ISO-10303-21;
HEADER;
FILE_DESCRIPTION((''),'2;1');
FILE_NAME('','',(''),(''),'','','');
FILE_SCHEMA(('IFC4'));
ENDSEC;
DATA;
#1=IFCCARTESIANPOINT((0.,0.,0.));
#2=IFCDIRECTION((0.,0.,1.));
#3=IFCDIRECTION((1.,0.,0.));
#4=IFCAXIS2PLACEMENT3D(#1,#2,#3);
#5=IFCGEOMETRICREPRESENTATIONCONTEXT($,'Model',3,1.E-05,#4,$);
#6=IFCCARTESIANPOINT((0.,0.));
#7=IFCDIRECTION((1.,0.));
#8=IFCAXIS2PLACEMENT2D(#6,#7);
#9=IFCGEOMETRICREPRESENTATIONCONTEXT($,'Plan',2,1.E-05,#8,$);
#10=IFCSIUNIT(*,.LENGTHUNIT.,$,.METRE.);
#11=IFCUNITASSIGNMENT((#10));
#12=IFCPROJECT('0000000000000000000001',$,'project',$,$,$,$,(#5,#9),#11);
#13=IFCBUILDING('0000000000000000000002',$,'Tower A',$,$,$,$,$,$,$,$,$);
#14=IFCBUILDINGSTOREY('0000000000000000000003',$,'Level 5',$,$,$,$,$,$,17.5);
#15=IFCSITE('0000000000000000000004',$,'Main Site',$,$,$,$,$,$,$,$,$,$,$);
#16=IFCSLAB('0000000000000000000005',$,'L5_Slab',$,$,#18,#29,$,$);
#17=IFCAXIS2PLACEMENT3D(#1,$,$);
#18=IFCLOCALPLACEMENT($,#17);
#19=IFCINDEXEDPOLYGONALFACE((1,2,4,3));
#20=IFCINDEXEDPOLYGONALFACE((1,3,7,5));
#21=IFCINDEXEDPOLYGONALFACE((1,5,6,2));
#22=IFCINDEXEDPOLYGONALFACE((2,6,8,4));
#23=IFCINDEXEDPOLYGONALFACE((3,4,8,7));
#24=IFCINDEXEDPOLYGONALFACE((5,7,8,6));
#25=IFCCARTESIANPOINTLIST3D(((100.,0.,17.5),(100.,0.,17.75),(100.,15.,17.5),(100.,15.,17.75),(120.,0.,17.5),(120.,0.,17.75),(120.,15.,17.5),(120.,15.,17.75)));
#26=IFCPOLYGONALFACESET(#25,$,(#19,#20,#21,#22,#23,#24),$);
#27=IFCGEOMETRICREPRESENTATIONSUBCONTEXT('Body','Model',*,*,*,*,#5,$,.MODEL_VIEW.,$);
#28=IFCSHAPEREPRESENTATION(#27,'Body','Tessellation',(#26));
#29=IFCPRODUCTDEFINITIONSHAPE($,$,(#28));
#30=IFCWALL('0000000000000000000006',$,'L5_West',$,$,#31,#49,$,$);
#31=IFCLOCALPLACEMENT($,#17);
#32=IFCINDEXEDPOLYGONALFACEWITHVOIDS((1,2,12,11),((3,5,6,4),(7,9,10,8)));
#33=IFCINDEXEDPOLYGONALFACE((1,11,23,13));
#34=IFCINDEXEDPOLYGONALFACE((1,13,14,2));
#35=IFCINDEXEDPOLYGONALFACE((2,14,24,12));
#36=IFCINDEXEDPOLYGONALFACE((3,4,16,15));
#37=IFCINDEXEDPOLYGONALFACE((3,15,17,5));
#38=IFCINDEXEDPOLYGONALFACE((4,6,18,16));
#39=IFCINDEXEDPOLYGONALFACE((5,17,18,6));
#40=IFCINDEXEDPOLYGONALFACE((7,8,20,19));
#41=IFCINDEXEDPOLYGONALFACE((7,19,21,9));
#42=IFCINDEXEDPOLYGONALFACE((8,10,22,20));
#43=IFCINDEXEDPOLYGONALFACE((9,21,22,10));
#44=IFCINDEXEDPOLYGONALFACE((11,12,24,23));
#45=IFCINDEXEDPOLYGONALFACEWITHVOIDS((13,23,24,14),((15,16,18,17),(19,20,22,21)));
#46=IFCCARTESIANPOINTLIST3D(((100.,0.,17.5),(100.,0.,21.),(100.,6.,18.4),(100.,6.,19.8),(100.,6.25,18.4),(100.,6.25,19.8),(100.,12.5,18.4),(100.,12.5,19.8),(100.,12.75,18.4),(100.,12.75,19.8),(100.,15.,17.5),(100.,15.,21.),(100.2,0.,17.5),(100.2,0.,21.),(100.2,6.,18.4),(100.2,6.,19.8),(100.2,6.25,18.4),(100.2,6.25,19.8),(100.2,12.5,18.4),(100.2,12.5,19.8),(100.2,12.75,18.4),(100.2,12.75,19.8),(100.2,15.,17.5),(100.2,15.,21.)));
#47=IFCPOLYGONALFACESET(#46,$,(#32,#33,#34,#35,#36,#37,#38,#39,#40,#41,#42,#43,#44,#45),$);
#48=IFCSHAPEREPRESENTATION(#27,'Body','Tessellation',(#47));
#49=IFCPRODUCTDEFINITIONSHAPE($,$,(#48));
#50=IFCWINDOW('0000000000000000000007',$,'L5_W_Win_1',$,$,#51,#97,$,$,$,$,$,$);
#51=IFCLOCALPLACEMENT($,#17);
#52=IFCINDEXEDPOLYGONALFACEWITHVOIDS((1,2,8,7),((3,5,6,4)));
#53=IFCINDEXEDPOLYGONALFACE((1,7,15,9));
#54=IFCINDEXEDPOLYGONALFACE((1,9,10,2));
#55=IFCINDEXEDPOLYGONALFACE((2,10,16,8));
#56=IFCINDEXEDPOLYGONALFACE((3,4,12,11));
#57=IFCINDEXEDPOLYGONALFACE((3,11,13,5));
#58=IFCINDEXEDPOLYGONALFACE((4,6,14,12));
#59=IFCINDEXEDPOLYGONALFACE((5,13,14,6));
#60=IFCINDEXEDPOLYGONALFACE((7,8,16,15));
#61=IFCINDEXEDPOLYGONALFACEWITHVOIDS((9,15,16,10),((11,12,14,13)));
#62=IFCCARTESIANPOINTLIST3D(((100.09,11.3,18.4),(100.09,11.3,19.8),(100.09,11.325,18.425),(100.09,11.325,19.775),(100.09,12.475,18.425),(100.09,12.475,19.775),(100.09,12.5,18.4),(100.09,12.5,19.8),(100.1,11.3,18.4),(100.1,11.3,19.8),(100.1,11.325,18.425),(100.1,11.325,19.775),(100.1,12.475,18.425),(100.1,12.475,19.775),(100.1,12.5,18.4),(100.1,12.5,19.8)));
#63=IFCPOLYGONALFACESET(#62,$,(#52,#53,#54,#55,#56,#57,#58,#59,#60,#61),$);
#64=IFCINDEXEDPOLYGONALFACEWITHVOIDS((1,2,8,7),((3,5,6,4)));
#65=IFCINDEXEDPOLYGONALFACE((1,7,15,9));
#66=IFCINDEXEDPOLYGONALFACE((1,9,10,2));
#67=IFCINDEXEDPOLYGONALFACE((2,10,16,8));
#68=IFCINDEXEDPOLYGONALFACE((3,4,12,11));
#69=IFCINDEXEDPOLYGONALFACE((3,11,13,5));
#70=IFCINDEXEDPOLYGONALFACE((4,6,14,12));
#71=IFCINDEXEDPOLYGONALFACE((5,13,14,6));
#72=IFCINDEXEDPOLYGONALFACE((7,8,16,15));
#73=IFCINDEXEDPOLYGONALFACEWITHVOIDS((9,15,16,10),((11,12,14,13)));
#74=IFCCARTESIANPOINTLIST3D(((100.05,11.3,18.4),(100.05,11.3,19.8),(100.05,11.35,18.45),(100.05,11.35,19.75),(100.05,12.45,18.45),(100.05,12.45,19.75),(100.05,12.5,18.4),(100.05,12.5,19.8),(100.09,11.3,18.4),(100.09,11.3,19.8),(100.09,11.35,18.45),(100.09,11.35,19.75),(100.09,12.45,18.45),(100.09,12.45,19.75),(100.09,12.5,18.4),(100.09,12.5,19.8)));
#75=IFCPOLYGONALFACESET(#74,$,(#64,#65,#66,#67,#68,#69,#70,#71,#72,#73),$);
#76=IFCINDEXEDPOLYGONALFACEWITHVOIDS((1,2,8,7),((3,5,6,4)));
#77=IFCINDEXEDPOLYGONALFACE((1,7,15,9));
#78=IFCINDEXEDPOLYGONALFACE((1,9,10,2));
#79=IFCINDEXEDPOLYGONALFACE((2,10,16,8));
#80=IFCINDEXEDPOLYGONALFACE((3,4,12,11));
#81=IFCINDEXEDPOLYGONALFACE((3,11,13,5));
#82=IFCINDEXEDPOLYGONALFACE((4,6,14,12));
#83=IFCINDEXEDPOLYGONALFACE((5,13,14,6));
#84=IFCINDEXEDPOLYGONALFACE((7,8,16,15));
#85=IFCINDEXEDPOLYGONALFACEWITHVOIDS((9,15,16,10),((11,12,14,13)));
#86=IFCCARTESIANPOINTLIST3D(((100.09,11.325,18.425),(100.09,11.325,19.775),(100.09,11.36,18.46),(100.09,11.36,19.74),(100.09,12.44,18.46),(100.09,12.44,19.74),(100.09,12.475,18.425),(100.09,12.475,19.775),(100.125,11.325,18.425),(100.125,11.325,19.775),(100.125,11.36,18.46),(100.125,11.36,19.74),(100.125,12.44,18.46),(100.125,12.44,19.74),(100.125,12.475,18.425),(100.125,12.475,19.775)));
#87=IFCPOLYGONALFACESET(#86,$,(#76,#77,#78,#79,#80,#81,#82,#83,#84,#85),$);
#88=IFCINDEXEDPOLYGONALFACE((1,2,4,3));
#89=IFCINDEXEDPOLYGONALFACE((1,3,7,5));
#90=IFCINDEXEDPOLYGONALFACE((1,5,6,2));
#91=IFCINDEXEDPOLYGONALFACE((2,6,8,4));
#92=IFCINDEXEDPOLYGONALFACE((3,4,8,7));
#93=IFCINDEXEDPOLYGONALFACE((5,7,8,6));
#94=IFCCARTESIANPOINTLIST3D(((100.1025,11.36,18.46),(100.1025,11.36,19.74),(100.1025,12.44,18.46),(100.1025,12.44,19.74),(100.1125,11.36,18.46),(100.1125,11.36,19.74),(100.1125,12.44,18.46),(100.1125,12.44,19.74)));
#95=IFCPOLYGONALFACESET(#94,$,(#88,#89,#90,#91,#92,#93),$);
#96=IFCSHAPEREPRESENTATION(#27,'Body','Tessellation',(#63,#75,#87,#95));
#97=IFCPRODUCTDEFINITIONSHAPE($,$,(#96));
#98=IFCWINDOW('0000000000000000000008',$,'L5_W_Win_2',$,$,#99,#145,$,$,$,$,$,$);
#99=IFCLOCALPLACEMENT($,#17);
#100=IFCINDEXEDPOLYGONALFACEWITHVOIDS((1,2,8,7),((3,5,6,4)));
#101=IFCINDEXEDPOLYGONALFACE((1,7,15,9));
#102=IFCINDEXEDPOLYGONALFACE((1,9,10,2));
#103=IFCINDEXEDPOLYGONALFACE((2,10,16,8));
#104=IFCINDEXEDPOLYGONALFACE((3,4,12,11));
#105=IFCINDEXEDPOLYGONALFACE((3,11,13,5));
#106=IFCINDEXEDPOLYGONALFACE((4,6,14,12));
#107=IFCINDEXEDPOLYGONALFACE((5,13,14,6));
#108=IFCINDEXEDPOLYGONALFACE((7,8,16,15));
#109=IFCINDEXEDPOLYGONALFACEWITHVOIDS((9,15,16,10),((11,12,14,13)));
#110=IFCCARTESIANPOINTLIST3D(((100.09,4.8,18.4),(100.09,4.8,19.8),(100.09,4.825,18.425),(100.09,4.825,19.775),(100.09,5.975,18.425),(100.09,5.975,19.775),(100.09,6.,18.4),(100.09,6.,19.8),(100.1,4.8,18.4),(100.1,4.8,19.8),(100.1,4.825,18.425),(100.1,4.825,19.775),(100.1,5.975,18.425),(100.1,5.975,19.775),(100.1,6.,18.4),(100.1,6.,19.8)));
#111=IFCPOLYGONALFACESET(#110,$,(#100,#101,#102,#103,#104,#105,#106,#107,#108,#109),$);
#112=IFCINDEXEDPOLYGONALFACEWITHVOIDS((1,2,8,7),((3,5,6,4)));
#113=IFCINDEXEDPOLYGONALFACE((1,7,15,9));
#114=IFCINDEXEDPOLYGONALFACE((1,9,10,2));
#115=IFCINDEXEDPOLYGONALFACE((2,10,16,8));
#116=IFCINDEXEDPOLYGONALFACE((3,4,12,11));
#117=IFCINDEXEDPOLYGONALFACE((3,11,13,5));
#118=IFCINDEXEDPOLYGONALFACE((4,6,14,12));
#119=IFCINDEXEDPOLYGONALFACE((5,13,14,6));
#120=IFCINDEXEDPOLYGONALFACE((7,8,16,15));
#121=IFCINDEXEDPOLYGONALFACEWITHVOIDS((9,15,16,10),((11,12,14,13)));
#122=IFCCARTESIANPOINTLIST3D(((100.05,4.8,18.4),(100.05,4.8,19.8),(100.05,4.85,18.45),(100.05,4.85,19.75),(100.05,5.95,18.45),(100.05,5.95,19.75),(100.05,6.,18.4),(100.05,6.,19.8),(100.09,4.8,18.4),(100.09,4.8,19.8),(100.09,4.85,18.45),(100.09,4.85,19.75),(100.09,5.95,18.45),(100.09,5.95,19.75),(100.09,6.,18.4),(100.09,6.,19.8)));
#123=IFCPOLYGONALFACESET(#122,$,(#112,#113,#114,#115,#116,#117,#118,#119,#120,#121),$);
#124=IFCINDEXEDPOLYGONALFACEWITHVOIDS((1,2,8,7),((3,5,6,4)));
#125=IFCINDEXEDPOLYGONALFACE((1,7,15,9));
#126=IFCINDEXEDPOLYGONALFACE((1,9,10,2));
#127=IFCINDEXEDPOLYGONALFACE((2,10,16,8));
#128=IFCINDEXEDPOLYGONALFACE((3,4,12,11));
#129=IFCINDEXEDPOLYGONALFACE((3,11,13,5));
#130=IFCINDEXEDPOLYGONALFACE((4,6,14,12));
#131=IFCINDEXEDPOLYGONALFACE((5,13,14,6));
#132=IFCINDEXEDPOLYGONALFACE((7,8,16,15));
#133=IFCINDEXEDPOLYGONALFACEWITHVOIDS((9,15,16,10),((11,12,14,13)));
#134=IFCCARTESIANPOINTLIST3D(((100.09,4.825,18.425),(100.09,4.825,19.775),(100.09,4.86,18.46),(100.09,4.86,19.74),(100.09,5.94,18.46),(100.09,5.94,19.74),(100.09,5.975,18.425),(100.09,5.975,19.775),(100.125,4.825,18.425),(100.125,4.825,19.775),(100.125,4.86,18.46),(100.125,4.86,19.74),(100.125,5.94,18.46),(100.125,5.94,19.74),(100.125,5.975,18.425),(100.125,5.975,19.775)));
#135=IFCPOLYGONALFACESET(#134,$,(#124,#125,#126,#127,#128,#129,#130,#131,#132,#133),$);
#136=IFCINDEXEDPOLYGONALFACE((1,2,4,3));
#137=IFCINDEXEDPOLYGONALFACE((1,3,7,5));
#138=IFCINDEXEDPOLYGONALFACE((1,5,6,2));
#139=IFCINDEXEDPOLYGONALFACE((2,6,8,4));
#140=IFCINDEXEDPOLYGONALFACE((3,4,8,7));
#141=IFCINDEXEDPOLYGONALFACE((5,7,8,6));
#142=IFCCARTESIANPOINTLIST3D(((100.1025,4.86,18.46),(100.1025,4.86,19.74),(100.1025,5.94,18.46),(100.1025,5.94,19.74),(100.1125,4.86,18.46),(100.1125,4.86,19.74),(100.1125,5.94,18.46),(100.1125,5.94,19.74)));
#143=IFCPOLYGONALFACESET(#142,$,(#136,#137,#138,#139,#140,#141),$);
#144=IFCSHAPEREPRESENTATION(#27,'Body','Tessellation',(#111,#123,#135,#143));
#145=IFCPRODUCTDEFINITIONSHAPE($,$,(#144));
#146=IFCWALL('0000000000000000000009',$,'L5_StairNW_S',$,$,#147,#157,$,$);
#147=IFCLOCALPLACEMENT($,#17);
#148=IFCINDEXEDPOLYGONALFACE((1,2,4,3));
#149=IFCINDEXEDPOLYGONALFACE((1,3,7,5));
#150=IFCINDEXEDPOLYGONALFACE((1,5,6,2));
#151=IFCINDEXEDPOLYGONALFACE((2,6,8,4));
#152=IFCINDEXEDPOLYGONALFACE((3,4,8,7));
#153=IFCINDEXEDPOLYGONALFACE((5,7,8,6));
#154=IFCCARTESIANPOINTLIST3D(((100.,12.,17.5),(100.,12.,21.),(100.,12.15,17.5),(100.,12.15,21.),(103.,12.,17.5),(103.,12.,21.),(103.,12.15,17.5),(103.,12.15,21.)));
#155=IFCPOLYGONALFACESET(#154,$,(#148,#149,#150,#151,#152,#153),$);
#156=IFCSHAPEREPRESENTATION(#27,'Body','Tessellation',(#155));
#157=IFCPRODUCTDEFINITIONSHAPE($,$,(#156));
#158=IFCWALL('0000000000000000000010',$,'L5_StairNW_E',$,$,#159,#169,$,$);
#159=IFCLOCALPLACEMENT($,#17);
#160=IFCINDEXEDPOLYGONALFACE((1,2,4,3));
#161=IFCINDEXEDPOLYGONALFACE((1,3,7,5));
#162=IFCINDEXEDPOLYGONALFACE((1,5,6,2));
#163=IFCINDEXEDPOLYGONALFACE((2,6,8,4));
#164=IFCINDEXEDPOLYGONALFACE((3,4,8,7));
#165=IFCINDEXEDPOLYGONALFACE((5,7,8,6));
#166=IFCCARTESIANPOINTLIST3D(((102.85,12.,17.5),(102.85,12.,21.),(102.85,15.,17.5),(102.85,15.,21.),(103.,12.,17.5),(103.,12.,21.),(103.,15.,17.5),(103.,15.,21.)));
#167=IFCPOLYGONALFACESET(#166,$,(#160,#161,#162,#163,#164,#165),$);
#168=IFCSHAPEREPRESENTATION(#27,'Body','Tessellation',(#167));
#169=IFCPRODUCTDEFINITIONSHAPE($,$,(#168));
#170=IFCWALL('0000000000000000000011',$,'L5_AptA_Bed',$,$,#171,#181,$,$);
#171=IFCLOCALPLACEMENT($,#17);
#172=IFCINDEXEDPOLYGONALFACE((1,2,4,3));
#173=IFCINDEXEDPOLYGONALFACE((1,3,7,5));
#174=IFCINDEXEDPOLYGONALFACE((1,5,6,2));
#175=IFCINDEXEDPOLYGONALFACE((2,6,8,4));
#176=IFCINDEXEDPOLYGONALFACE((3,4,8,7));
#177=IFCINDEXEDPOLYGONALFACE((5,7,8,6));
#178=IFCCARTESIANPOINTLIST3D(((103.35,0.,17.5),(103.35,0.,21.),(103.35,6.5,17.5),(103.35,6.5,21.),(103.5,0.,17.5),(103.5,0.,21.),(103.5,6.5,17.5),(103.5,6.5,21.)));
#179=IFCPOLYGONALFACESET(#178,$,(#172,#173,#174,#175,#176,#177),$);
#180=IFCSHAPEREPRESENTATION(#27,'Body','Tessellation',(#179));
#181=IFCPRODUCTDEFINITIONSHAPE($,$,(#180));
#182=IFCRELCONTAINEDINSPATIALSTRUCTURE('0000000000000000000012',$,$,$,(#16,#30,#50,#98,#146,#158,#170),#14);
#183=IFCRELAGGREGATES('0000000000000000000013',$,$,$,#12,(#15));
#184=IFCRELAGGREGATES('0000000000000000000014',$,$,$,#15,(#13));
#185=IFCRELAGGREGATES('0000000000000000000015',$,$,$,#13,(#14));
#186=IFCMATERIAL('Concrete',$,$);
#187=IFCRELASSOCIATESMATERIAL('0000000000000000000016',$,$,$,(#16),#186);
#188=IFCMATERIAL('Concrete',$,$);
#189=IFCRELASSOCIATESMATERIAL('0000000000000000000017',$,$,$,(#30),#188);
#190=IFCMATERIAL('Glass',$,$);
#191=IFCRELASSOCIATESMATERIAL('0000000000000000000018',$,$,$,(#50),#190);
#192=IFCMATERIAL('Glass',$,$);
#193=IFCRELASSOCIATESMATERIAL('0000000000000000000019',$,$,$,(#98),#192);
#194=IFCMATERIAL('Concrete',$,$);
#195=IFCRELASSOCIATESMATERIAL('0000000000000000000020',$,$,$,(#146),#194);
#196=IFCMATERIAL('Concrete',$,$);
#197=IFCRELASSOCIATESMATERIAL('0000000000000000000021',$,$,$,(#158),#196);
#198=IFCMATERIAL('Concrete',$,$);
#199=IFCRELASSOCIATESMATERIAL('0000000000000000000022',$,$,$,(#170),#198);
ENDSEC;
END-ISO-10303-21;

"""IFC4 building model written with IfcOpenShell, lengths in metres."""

from ifc_helpers import new_model, si_unit, frame, origin_with_axes, origin_2d_with_axis, place, context, subcontext, project, spatial, line, indexed_curve, outline, extrude, material, element, fill, save


model = new_model("IFC4")

# Units and contexts
model_context = context("Model", 3, precision=1e-05, world=origin_with_axes())
plan_context = context("Plan", 2, precision=1e-05, world=origin_2d_with_axis())
body_context = subcontext(model_context, "Body", "Model", "MODEL_VIEW")
ifc_project = project(units=[si_unit("LENGTHUNIT", "METRE")], contexts=[model_context, plan_context])

# Site, building, storey
site = spatial("IfcSite", under=ifc_project, Name="Main Site")
building = spatial("IfcBuilding", under=site, Name="Tower A")
storey = spatial("IfcBuildingStorey", under=building, Name="Level 5", Elevation=17.5)

# Slab
ifc_material_1 = material(Name="Concrete")
slab_placement = place(None, frame((100.0, 0.0, 17.5), z_axis=(0.0, 0.0, 1.0), x_axis=(1.0, 0.0, 0.0)))
element("IfcSlab", 1, at=slab_placement, inside=storey, material=ifc_material_1, Name="L5_Slab", context=body_context, shape_type="SweptSolid", body=[
    extrude(outline(indexed_curve([(0.0, 0.0), (20.0, 0.0), (20.0, 15.0), (0.0, 15.0)])), None, (0.0, 0.0, 1.0), 0.25),
])

# Wall, openings, windows
ifc_material_2 = material(Name="Concrete")
wall_1_placement = place(None, frame((100.0, 15.0, 17.5), z_axis=(0.0, 0.0, 1.0), x_axis=(0.0, -1.0, 0.0)))
wall_1 = element("IfcWall", 2, at=wall_1_placement, inside=storey, material=ifc_material_2, Name="L5_West", context=body_context, shape_type="SweptSolid", body=[
    extrude(outline(indexed_curve([(0.0, 0.0), (0.0, 0.2), (15.0, 0.2), (15.0, 0.0), (0.0, 0.0)], self_intersect=False)), origin_with_axes(), (0.0, 0.0, 1.0), 3.5),
])
opening_1_placement = place(wall_1_placement, frame((2.5, 0.0, 0.9), z_axis=(0.0, 0.0, 1.0), x_axis=(0.0, 1.0, 0.0)))
opening_1 = element("IfcOpeningElement", 3, at=opening_1_placement, cuts=wall_1, context=body_context, shape_type="SweptSolid", body=[
    extrude(outline(indexed_curve([(0.0, 0.0), (0.0, 0.25), (1.2, 0.25), (1.2, 0.0), (0.0, 0.0)], self_intersect=False)), origin_with_axes(), (0.0, 0.0, 1.0), 1.4),
])
opening_2_placement = place(wall_1_placement, frame((9.0, 0.0, 0.9), z_axis=(0.0, 0.0, 1.0), x_axis=(0.0, 1.0, 0.0)))
opening_2 = element("IfcOpeningElement", 4, at=opening_2_placement, cuts=wall_1, context=body_context, shape_type="SweptSolid", body=[
    extrude(outline(indexed_curve([(0.0, 0.0), (0.0, 0.25), (1.2, 0.25), (1.2, 0.0), (0.0, 0.0)], self_intersect=False)), origin_with_axes(), (0.0, 0.0, 1.0), 1.4),
])
ifc_material_3 = material(Name="Glass")
window_1_placement = place(None, frame((100.0, 12.5, 18.4), z_axis=(0.0, 0.0, 1.0), x_axis=(0.0, -1.0, 0.0)))
window_1 = element("IfcWindow", 5, at=window_1_placement, inside=storey, material=ifc_material_3, Name="L5_W_Win_1", context=body_context, shape_type="SweptSolid", body=[
    extrude(outline(indexed_curve([(0.0, 0.0), (1.2, 0.0), (1.2, 1.4), (0.0, 1.4)], segments=[line(1, 2, 3, 4, 1)]), holes=[indexed_curve([(0.025, 0.025), (1.175, 0.025), (1.175, 1.375), (0.025, 1.375)], segments=[line(1, 2, 3, 4, 1)])]), frame((0.0, 0.09, 0.0), z_axis=(0.0, -1.0, 0.0), x_axis=(1.0, 0.0, 0.0)), (0.0, 0.0, -1.0), 0.01),
    extrude(outline(indexed_curve([(0.0, 0.0), (1.2, 0.0), (1.2, 1.4), (0.0, 1.4)], segments=[line(1, 2, 3, 4, 1)]), holes=[indexed_curve([(0.05, 0.05), (1.15, 0.05), (1.15, 1.35), (0.05, 1.35)], segments=[line(1, 2, 3, 4, 1)])]), frame((0.0, 0.05, 0.0), z_axis=(0.0, -1.0, 0.0), x_axis=(1.0, 0.0, 0.0)), (0.0, 0.0, -1.0), 0.04),
    extrude(outline(indexed_curve([(0.0, 0.0), (1.15, 0.0), (1.15, 1.35), (0.0, 1.35)], segments=[line(1, 2, 3, 4, 1)]), holes=[indexed_curve([(0.035, 0.035), (1.115, 0.035), (1.115, 1.315), (0.035, 1.315)], segments=[line(1, 2, 3, 4, 1)])]), frame((0.025, 0.09, 0.025), z_axis=(0.0, -1.0, 0.0), x_axis=(1.0, 0.0, 0.0)), (0.0, 0.0, -1.0), 0.035),
    extrude(outline(indexed_curve([(0.035, 0.035), (1.115, 0.035), (1.115, 1.315), (0.035, 1.315)], segments=[line(1, 2, 3, 4, 1)])), frame((0.025, 0.1025, 0.025), z_axis=(0.0, -1.0, 0.0), x_axis=(1.0, 0.0, 0.0)), (0.0, 0.0, -1.0), 0.01),
])
fill(opening_1, window_1)
ifc_material_4 = material(Name="Glass")
window_2_placement = place(None, frame((100.0, 6.0, 18.4), z_axis=(0.0, 0.0, 1.0), x_axis=(0.0, -1.0, 0.0)))
window_2 = element("IfcWindow", 6, at=window_2_placement, inside=storey, material=ifc_material_4, Name="L5_W_Win_2", context=body_context, shape_type="SweptSolid", body=[
    extrude(outline(indexed_curve([(0.0, 0.0), (1.2, 0.0), (1.2, 1.4), (0.0, 1.4)], segments=[line(1, 2, 3, 4, 1)]), holes=[indexed_curve([(0.025, 0.025), (1.175, 0.025), (1.175, 1.375), (0.025, 1.375)], segments=[line(1, 2, 3, 4, 1)])]), frame((0.0, 0.09, 0.0), z_axis=(0.0, -1.0, 0.0), x_axis=(1.0, 0.0, 0.0)), (0.0, 0.0, -1.0), 0.01),
    extrude(outline(indexed_curve([(0.0, 0.0), (1.2, 0.0), (1.2, 1.4), (0.0, 1.4)], segments=[line(1, 2, 3, 4, 1)]), holes=[indexed_curve([(0.05, 0.05), (1.15, 0.05), (1.15, 1.35), (0.05, 1.35)], segments=[line(1, 2, 3, 4, 1)])]), frame((0.0, 0.05, 0.0), z_axis=(0.0, -1.0, 0.0), x_axis=(1.0, 0.0, 0.0)), (0.0, 0.0, -1.0), 0.04),
    extrude(outline(indexed_curve([(0.0, 0.0), (1.15, 0.0), (1.15, 1.35), (0.0, 1.35)], segments=[line(1, 2, 3, 4, 1)]), holes=[indexed_curve([(0.035, 0.035), (1.115, 0.035), (1.115, 1.315), (0.035, 1.315)], segments=[line(1, 2, 3, 4, 1)])]), frame((0.025, 0.09, 0.025), z_axis=(0.0, -1.0, 0.0), x_axis=(1.0, 0.0, 0.0)), (0.0, 0.0, -1.0), 0.035),
    extrude(outline(indexed_curve([(0.035, 0.035), (1.115, 0.035), (1.115, 1.315), (0.035, 1.315)], segments=[line(1, 2, 3, 4, 1)])), frame((0.025, 0.1025, 0.025), z_axis=(0.0, -1.0, 0.0), x_axis=(1.0, 0.0, 0.0)), (0.0, 0.0, -1.0), 0.01),
])
fill(opening_2, window_2)

# Walls
ifc_material_5 = material(Name="Concrete")
wall_2_placement = place(None, frame((100.0, 12.0, 17.5), z_axis=(0.0, 0.0, 1.0), x_axis=(1.0, 0.0, 0.0)))
element("IfcWall", 7, at=wall_2_placement, inside=storey, material=ifc_material_5, Name="L5_StairNW_S", context=body_context, shape_type="SweptSolid", body=[
    extrude(outline(indexed_curve([(0.0, 0.0), (0.0, 0.15), (3.0, 0.15), (3.0, 0.0), (0.0, 0.0)], self_intersect=False)), origin_with_axes(), (0.0, 0.0, 1.0), 3.5),
])
ifc_material_6 = material(Name="Concrete")
wall_3_placement = place(None, frame((103.0, 12.0, 17.5), z_axis=(0.0, 0.0, 1.0), x_axis=(0.0, 1.0, 0.0)))
element("IfcWall", 8, at=wall_3_placement, inside=storey, material=ifc_material_6, Name="L5_StairNW_E", context=body_context, shape_type="SweptSolid", body=[
    extrude(outline(indexed_curve([(0.0, 0.0), (0.0, 0.15), (3.0, 0.15), (3.0, 0.0), (0.0, 0.0)], self_intersect=False)), origin_with_axes(), (0.0, 0.0, 1.0), 3.5),
])

# Wall
ifc_material_7 = material(Name="Concrete")
wall_4_placement = place(None, frame((103.5, 0.0, 17.5), z_axis=(0.0, 0.0, 1.0), x_axis=(0.0, 1.0, 0.0)))
element("IfcWall", 9, at=wall_4_placement, inside=storey, material=ifc_material_7, Name="L5_AptA_Bed", context=body_context, shape_type="SweptSolid", body=[
    extrude(outline(indexed_curve([(0.0, 0.0), (0.0, 0.15), (6.5, 0.15), (6.5, 0.0), (0.0, 0.0)], self_intersect=False)), origin_with_axes(), (0.0, 0.0, 1.0), 3.5),
])

save(model, "model.ifc")
